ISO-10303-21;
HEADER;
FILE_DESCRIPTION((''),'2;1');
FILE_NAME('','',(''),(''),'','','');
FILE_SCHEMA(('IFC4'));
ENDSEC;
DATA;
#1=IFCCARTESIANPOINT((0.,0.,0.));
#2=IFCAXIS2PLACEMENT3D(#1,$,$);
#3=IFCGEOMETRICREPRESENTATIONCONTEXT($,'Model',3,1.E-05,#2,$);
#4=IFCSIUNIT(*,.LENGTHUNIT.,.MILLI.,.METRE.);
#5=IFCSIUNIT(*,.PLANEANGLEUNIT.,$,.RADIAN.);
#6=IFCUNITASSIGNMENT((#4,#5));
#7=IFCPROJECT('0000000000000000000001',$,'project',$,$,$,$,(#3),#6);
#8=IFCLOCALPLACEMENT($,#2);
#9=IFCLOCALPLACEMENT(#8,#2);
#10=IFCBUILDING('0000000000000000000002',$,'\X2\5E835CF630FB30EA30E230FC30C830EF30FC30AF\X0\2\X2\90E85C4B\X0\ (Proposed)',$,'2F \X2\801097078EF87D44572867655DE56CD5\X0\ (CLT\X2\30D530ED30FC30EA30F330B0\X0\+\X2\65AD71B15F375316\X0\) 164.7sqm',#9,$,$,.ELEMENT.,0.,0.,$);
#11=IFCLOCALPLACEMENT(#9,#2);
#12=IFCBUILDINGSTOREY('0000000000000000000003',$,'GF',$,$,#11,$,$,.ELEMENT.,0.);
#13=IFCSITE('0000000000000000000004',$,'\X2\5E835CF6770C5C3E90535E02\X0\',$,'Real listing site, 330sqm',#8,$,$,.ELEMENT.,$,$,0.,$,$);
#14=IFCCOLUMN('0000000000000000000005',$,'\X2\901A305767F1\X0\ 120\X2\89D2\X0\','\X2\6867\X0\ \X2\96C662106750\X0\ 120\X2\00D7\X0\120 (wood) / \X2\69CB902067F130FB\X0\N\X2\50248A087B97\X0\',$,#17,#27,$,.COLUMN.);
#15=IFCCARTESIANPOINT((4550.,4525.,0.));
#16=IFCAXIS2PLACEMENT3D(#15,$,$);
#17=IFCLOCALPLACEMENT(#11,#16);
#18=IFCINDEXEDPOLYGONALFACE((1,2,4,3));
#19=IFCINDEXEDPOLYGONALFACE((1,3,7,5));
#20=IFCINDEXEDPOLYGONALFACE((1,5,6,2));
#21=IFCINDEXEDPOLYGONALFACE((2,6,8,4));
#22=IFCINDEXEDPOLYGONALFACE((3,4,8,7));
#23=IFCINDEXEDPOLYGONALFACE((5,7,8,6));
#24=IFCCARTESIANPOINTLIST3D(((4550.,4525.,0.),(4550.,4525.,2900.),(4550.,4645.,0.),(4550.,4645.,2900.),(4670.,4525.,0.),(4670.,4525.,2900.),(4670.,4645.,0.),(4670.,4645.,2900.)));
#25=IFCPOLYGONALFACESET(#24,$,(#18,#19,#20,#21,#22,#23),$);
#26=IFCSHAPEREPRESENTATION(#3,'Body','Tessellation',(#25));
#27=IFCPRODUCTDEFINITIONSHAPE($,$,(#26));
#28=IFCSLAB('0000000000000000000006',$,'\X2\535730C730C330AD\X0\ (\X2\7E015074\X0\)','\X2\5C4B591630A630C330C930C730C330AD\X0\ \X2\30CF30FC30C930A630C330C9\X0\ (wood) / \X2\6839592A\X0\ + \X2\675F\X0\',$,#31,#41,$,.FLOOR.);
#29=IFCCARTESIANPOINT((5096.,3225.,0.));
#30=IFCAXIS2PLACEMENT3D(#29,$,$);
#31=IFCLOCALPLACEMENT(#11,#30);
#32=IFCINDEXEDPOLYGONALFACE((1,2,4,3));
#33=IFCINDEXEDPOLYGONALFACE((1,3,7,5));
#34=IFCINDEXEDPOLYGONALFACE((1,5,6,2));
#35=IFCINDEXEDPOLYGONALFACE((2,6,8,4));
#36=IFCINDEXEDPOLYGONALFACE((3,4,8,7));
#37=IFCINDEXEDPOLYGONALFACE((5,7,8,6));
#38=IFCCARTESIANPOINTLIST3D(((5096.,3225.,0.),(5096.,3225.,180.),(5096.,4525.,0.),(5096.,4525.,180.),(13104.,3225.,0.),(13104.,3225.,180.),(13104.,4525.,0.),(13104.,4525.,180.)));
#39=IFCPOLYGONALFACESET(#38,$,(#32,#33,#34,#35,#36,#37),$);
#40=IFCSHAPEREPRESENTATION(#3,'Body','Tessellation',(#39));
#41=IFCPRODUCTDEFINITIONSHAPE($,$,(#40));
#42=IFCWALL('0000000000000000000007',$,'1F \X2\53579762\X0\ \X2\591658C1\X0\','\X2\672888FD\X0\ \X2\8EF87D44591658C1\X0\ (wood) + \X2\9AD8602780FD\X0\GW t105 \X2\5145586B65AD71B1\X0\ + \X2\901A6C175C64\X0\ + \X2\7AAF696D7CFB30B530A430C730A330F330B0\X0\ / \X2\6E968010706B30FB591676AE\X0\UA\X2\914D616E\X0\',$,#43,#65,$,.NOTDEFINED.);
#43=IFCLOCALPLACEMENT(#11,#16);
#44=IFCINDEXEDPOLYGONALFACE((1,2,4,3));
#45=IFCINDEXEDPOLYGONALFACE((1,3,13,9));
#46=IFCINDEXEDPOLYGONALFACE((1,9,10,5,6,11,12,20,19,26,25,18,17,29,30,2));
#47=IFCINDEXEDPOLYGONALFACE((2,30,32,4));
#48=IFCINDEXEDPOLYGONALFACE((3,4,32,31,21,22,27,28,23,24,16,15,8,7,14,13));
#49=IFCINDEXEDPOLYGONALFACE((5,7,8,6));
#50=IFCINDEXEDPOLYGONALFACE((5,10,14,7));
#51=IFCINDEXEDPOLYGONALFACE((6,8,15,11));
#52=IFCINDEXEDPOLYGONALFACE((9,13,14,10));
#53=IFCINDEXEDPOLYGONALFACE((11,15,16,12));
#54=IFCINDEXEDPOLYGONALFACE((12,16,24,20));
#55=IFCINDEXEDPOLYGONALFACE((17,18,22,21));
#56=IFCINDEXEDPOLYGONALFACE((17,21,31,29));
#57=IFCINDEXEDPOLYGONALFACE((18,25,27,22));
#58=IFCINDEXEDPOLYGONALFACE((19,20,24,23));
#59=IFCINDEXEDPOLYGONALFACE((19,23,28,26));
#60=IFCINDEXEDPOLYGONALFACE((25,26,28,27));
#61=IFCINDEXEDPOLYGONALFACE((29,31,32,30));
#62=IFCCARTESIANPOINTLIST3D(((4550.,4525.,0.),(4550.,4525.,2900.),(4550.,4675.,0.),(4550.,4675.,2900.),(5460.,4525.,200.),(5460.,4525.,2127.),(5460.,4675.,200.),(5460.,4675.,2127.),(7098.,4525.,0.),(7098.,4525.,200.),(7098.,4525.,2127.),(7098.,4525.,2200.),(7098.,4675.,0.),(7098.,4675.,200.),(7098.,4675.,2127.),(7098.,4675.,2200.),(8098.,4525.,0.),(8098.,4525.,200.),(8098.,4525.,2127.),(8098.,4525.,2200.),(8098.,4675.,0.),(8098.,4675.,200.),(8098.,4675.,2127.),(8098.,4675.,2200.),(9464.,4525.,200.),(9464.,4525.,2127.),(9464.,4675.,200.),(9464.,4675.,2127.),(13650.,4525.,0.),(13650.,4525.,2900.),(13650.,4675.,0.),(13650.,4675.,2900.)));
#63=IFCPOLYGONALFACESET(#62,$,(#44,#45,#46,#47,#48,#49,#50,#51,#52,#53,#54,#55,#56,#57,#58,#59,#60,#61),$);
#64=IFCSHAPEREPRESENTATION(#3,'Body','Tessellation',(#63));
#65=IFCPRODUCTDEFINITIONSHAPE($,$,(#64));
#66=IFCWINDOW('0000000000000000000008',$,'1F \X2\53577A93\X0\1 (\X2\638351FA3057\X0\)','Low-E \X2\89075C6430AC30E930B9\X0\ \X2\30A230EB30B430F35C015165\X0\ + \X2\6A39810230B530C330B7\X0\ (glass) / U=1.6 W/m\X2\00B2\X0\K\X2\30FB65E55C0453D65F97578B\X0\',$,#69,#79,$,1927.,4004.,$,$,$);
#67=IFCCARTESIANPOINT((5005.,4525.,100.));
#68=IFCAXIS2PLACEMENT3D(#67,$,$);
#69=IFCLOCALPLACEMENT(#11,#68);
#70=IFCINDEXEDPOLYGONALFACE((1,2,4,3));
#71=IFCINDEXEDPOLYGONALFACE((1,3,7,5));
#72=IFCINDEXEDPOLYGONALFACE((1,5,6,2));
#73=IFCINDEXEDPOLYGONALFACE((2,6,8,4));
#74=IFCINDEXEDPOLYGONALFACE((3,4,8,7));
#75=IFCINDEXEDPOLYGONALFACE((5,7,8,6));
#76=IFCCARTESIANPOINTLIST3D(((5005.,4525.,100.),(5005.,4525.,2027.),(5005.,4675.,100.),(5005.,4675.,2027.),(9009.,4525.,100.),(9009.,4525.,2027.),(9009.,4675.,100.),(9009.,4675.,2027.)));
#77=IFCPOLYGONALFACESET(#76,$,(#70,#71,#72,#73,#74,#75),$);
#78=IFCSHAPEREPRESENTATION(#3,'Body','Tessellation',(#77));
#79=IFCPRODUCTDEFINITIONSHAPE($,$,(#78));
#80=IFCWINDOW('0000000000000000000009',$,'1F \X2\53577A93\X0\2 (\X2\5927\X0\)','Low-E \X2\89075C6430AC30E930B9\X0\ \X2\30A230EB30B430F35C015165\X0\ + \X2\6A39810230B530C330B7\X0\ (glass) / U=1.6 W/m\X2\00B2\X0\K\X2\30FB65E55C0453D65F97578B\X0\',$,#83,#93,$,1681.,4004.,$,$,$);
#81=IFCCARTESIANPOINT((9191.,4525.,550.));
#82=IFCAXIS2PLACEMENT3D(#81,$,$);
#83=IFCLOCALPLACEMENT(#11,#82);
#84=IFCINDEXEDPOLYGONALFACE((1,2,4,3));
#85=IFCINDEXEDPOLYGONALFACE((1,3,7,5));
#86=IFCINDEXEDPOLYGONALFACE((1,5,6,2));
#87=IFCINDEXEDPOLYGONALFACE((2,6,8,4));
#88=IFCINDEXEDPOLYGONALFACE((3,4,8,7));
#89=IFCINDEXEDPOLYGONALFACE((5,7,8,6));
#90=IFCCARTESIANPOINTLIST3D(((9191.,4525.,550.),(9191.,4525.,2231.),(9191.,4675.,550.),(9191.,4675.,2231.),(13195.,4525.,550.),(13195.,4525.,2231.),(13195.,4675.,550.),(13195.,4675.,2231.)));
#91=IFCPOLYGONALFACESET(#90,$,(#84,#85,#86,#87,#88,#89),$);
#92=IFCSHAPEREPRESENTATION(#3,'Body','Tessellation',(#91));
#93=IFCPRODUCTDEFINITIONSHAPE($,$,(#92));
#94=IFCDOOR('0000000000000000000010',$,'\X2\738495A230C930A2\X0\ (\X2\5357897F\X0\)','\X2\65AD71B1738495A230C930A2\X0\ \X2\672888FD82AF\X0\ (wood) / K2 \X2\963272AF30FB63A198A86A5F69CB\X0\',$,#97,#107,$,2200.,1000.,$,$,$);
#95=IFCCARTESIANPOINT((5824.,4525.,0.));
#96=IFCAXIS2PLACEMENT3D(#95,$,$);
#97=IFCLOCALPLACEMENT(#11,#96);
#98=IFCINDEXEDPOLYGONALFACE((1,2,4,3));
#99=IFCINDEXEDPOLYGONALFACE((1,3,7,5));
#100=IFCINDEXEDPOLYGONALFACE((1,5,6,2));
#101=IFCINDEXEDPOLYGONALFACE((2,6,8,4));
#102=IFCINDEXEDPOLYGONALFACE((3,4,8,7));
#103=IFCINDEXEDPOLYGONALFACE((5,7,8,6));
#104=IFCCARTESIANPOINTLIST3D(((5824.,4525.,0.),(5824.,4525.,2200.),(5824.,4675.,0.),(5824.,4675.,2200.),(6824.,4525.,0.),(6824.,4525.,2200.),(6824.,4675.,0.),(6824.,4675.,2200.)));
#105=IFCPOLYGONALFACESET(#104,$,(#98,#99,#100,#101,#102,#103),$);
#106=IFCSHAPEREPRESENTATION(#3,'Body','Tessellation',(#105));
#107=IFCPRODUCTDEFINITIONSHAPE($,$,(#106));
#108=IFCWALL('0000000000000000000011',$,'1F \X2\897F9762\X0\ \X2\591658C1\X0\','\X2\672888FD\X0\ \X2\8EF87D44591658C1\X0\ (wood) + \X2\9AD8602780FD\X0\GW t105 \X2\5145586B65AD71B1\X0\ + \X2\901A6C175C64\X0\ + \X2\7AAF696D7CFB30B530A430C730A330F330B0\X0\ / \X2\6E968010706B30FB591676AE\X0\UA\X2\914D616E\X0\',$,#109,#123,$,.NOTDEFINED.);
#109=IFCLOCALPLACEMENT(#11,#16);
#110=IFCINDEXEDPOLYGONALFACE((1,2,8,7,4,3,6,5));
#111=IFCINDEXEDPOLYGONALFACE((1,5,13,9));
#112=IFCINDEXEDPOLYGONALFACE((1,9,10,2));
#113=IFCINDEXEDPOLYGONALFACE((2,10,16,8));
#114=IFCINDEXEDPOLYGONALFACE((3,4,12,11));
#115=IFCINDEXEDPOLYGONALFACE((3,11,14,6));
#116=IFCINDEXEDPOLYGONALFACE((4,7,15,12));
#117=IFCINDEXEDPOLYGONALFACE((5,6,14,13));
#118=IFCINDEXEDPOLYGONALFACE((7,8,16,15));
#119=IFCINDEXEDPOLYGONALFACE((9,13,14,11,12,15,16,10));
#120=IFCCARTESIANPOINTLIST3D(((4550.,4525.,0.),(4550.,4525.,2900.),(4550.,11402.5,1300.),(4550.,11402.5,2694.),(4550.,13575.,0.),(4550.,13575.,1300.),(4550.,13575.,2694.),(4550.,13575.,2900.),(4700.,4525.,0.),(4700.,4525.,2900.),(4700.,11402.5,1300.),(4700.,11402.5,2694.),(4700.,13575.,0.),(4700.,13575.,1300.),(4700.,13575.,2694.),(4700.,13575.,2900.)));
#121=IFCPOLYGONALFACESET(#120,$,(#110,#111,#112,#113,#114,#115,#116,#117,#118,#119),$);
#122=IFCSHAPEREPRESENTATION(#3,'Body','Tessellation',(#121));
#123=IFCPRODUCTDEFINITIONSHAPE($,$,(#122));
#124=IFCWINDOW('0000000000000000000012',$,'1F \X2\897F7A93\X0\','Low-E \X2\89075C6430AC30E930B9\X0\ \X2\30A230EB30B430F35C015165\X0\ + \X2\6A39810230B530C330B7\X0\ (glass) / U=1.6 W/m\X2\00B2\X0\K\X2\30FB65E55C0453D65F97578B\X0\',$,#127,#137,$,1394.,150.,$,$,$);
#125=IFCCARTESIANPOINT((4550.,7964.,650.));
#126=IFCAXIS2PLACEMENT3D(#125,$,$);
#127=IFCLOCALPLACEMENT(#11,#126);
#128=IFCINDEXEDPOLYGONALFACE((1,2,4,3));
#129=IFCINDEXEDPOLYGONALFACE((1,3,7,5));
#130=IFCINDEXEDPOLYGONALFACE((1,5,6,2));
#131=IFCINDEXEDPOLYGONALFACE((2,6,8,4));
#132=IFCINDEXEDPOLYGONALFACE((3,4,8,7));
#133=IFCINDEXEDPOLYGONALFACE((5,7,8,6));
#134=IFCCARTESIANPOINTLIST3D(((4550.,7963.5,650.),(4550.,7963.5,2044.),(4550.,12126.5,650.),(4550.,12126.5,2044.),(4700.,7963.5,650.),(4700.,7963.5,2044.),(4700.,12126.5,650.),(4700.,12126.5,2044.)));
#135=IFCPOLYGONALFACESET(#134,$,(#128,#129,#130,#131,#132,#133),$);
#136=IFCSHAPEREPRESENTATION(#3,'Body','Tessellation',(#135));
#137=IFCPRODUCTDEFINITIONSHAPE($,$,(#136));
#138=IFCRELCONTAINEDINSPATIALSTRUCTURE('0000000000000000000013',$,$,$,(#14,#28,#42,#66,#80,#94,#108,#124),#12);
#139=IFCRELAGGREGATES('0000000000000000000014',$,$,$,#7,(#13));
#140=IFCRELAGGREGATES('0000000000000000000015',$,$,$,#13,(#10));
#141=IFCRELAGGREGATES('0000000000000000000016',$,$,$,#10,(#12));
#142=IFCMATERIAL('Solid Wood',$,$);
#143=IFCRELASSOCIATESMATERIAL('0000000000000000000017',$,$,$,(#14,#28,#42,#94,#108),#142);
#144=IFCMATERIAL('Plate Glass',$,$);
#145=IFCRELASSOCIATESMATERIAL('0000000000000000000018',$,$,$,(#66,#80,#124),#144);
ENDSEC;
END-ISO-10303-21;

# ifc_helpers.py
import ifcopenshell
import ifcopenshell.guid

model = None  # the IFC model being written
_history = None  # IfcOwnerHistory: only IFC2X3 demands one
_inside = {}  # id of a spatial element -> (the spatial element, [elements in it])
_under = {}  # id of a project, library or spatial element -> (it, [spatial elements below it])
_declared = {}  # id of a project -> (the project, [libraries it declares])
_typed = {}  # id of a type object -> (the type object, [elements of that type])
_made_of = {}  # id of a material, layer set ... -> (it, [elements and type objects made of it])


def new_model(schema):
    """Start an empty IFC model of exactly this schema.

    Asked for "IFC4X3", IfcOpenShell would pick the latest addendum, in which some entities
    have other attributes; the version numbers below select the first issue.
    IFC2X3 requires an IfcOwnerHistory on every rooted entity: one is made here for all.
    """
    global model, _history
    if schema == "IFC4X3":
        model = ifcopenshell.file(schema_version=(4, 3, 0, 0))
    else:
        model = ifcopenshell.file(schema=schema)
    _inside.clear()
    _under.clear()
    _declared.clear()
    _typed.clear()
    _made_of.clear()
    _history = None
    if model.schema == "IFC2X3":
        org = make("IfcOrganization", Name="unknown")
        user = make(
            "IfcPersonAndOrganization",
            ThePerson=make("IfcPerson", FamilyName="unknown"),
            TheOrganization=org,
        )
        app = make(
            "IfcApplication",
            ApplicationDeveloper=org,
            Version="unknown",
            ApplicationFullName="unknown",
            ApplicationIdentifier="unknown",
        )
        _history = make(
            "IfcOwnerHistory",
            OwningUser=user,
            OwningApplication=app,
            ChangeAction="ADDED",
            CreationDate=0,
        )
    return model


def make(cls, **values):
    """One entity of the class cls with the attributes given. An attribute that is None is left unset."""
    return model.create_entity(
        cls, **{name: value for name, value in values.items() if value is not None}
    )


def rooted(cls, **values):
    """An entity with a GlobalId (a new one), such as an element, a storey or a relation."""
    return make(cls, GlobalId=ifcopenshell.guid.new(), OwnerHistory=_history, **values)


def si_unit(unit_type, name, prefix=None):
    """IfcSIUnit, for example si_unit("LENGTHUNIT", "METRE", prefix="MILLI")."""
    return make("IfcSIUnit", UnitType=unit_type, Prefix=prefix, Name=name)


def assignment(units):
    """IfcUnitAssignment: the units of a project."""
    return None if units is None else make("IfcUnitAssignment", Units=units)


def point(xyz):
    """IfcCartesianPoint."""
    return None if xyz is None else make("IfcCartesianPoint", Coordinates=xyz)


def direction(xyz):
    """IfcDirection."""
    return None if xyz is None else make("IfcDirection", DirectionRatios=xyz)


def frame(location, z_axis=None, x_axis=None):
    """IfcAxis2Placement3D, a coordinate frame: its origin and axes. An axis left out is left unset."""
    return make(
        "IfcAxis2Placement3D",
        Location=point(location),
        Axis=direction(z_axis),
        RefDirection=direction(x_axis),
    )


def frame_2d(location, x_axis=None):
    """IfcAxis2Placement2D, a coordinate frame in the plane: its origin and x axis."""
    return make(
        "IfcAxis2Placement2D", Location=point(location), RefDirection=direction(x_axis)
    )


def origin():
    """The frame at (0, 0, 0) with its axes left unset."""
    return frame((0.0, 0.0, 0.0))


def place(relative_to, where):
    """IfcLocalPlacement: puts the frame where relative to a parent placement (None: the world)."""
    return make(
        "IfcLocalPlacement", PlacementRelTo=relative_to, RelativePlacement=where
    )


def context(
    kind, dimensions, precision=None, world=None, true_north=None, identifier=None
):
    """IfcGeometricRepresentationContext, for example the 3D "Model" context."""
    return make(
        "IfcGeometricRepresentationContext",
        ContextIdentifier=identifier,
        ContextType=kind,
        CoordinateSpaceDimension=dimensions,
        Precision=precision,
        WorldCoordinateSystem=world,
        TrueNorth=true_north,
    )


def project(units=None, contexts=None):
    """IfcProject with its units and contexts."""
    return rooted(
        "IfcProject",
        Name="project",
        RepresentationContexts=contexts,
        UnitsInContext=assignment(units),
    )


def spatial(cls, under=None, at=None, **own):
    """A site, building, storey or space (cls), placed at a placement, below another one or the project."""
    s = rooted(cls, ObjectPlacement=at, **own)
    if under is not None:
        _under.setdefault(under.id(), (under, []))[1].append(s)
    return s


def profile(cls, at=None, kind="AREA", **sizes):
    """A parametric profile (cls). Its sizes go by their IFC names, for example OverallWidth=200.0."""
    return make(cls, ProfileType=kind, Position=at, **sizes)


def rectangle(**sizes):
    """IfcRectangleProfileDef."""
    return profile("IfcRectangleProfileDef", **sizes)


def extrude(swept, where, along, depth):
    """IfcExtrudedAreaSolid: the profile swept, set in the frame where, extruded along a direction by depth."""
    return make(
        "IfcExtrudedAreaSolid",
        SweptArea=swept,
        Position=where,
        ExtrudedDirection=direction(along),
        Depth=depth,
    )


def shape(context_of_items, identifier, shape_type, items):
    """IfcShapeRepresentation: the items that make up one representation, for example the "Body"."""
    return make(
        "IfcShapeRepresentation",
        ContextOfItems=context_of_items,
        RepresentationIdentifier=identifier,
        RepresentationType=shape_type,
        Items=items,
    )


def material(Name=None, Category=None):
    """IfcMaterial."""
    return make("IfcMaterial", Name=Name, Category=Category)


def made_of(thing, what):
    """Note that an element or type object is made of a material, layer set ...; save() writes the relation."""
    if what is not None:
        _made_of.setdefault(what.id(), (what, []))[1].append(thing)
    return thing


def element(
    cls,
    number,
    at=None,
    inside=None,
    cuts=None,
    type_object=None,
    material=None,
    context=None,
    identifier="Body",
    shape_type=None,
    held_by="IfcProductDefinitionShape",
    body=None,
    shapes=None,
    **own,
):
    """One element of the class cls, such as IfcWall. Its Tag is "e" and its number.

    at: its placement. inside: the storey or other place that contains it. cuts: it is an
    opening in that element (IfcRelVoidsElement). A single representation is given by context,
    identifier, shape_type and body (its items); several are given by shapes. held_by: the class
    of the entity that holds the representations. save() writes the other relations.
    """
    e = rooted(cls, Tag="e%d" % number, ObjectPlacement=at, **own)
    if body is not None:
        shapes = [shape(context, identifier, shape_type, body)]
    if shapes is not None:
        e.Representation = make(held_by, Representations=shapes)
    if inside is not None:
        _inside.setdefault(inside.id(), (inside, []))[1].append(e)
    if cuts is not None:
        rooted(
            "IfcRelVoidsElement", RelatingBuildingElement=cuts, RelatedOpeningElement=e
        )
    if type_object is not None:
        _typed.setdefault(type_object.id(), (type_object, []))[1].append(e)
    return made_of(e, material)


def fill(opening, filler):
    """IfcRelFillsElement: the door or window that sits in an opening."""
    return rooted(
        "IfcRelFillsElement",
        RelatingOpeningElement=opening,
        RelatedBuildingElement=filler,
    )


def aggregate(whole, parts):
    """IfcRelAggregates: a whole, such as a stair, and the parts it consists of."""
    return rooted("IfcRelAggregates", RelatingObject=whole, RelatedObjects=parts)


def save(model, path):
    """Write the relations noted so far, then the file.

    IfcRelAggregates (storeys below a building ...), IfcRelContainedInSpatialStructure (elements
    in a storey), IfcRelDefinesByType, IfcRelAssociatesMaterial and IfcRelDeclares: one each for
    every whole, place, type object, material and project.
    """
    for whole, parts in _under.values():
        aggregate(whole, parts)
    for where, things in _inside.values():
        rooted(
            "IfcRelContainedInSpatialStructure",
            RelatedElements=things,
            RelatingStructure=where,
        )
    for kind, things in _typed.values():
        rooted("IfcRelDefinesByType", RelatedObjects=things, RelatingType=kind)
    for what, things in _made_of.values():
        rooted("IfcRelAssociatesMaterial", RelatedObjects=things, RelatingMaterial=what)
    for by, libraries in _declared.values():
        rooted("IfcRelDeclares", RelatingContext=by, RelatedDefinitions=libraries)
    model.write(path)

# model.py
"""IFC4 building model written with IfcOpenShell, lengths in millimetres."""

from ifc_helpers import new_model, si_unit, frame, frame_2d, origin, place, context, project, spatial, rectangle, extrude, material, element, fill, save


model = new_model("IFC4")

# Units and contexts
model_context = context("Model", 3, precision=1e-05, world=origin())
ifc_project = project(units=[si_unit("LENGTHUNIT", "METRE", prefix="MILLI"), si_unit("PLANEANGLEUNIT", "RADIAN")], contexts=[model_context])

# Site, building, storey
site_placement = place(None, origin())
site = spatial("IfcSite", under=ifc_project, at=site_placement, Name="広島県尾道市", ObjectType="Real listing site, 330sqm", CompositionType="ELEMENT", RefElevation=0.0)
building_placement = place(site_placement, origin())
building = spatial("IfcBuilding", under=site, at=building_placement, Name="広島・リモートワーク2部屋 (Proposed)", ObjectType="2F 耐震軸組在来工法 (CLTフローリング+断熱強化) 164.7sqm", CompositionType="ELEMENT", ElevationOfRefHeight=0.0, ElevationOfTerrain=0.0)
storey_placement = place(building_placement, origin())
storey = spatial("IfcBuildingStorey", under=building, at=storey_placement, Name="GF", CompositionType="ELEMENT", Elevation=0.0)

# Column
ifc_material_1 = material(Name="Solid Wood")
column_placement = place(storey_placement, frame((4550.0, 4525.0, 0.0)))
element("IfcColumn", 1, at=column_placement, inside=storey, material=ifc_material_1, Name="通し柱 120角", Description="桧 集成材 120×120 (wood) / 構造柱・N値計算", PredefinedType="COLUMN", context=model_context, shape_type="SweptSolid", body=[
    extrude(rectangle(XDim=120.0, YDim=120.0, at=frame_2d((60.0, 60.0))), frame((4550.0, 4525.0, 0.0)), (0.0, 0.0, 1.0), 2900.0),
])

# Slab
slab_1_placement = place(storey_placement, frame((5096.0, 3225.0, 0.0)))
element("IfcSlab", 2, at=slab_1_placement, inside=storey, material=ifc_material_1, Name="南デッキ (縁側)", Description="屋外ウッドデッキ ハードウッド (wood) / 根太 + 束", PredefinedType="FLOOR", context=model_context, shape_type="SweptSolid", body=[
    extrude(rectangle(XDim=8008.0, YDim=1300.0, at=frame_2d((4004.0, 650.0))), frame((5096.0, 3225.0, 0.0)), (0.0, 0.0, 1.0), 180.0),
])

# Wall, openings, windows, door
wall_1_placement = place(storey_placement, frame((4550.0, 4525.0, 0.0)))
wall_1 = element("IfcWall", 3, at=wall_1_placement, inside=storey, material=ifc_material_1, Name="1F 南面 外壁", Description="木製 軸組外壁 (wood) + 高性能GW t105 充填断熱 + 通気層 + 窯業系サイディング / 準耐火・外皮UA配慮", PredefinedType="NOTDEFINED", context=model_context, shape_type="SweptSolid", body=[
    extrude(rectangle(XDim=9100.0, YDim=150.0, at=frame_2d((4550.0, 75.0))), frame((4550.0, 4525.0, 0.0)), (0.0, 0.0, 1.0), 2900.0),
])
opening_1_placement = place(storey_placement, frame((5005.0, 4525.0, 100.0)))
opening_1 = element("IfcOpeningElement", 4, at=opening_1_placement, cuts=wall_1, PredefinedType="NOTDEFINED", context=model_context, shape_type="SweptSolid", body=[
    extrude(rectangle(XDim=4004.0, YDim=150.0, at=frame_2d((2002.0, 75.0))), frame((5005.0, 4525.0, 100.0)), (0.0, 0.0, 1.0), 1927.0),
])
opening_2_placement = place(storey_placement, frame((9191.0, 4525.0, 550.0)))
opening_2 = element("IfcOpeningElement", 5, at=opening_2_placement, cuts=wall_1, PredefinedType="NOTDEFINED", context=model_context, shape_type="SweptSolid", body=[
    extrude(rectangle(XDim=4004.0, YDim=150.0, at=frame_2d((2002.0, 75.0))), frame((9191.0, 4525.0, 550.0)), (0.0, 0.0, 1.0), 1681.0),
])
opening_3_placement = place(storey_placement, frame((5824.0, 4525.0, 0.0)))
opening_3 = element("IfcOpeningElement", 6, at=opening_3_placement, cuts=wall_1, PredefinedType="NOTDEFINED", context=model_context, shape_type="SweptSolid", body=[
    extrude(rectangle(XDim=1000.0, YDim=150.0, at=frame_2d((500.0, 75.0))), frame((5824.0, 4525.0, 0.0)), (0.0, 0.0, 1.0), 2200.0),
])
ifc_material_2 = material(Name="Plate Glass")
window_1_placement = place(storey_placement, frame((5005.0, 4525.0, 100.0)))
window_1 = element("IfcWindow", 7, at=window_1_placement, inside=storey, material=ifc_material_2, Name="1F 南窓1 (掃出し)", Description="Low-E 複層ガラス アルゴン封入 + 樹脂サッシ (glass) / U=1.6 W/m²K・日射取得型", OverallHeight=1927.0, OverallWidth=4004.0, context=model_context, shape_type="SweptSolid", body=[
    extrude(rectangle(XDim=4004.0, YDim=150.0, at=frame_2d((2002.0, 75.0))), frame((5005.0, 4525.0, 100.0)), (0.0, 0.0, 1.0), 1927.0),
])
fill(opening_1, window_1)
window_2_placement = place(storey_placement, frame((9191.0, 4525.0, 550.0)))
window_2 = element("IfcWindow", 8, at=window_2_placement, inside=storey, material=ifc_material_2, Name="1F 南窓2 (大)", Description="Low-E 複層ガラス アルゴン封入 + 樹脂サッシ (glass) / U=1.6 W/m²K・日射取得型", OverallHeight=1681.0, OverallWidth=4004.0, context=model_context, shape_type="SweptSolid", body=[
    extrude(rectangle(XDim=4004.0, YDim=150.0, at=frame_2d((2002.0, 75.0))), frame((9191.0, 4525.0, 550.0)), (0.0, 0.0, 1.0), 1681.0),
])
fill(opening_2, window_2)
door_placement = place(storey_placement, frame((5824.0, 4525.0, 0.0)))
door = element("IfcDoor", 9, at=door_placement, inside=storey, material=ifc_material_1, Name="玄関ドア (南西)", Description="断熱玄関ドア 木製芯 (wood) / K2 防犯・採風機構", OverallHeight=2200.0, OverallWidth=1000.0, context=model_context, shape_type="SweptSolid", body=[
    extrude(rectangle(XDim=1000.0, YDim=150.0, at=frame_2d((500.0, 75.0))), frame((5824.0, 4525.0, 0.0)), (0.0, 0.0, 1.0), 2200.0),
])
fill(opening_3, door)

# Wall, opening, window
wall_2_placement = place(storey_placement, frame((4550.0, 4525.0, 0.0)))
wall_2 = element("IfcWall", 10, at=wall_2_placement, inside=storey, material=ifc_material_1, Name="1F 西面 外壁", Description="木製 軸組外壁 (wood) + 高性能GW t105 充填断熱 + 通気層 + 窯業系サイディング / 準耐火・外皮UA配慮", PredefinedType="NOTDEFINED", context=model_context, shape_type="SweptSolid", body=[
    extrude(rectangle(XDim=150.0, YDim=9050.0, at=frame_2d((75.0, 4525.0))), frame((4550.0, 4525.0, 0.0)), (0.0, 0.0, 1.0), 2900.0),
])
opening_4_placement = place(storey_placement, frame((4550.0, 7964.0, 650.0)))
opening_4 = element("IfcOpeningElement", 11, at=opening_4_placement, cuts=wall_2, PredefinedType="NOTDEFINED", context=model_context, shape_type="SweptSolid", body=[
    extrude(rectangle(XDim=150.0, YDim=4163.0, at=frame_2d((75.0, 2081.0))), frame((4550.0, 7964.0, 650.0)), (0.0, 0.0, 1.0), 1394.0),
])
window_3_placement = place(storey_placement, frame((4550.0, 7964.0, 650.0)))
window_3 = element("IfcWindow", 12, at=window_3_placement, inside=storey, material=ifc_material_2, Name="1F 西窓", Description="Low-E 複層ガラス アルゴン封入 + 樹脂サッシ (glass) / U=1.6 W/m²K・日射取得型", OverallHeight=1394.0, OverallWidth=150.0, context=model_context, shape_type="SweptSolid", body=[
    extrude(rectangle(XDim=150.0, YDim=4163.0, at=frame_2d((75.0, 2081.0))), frame((4550.0, 7964.0, 650.0)), (0.0, 0.0, 1.0), 1394.0),
])
fill(opening_4, window_3)

save(model, "model.ifc")
